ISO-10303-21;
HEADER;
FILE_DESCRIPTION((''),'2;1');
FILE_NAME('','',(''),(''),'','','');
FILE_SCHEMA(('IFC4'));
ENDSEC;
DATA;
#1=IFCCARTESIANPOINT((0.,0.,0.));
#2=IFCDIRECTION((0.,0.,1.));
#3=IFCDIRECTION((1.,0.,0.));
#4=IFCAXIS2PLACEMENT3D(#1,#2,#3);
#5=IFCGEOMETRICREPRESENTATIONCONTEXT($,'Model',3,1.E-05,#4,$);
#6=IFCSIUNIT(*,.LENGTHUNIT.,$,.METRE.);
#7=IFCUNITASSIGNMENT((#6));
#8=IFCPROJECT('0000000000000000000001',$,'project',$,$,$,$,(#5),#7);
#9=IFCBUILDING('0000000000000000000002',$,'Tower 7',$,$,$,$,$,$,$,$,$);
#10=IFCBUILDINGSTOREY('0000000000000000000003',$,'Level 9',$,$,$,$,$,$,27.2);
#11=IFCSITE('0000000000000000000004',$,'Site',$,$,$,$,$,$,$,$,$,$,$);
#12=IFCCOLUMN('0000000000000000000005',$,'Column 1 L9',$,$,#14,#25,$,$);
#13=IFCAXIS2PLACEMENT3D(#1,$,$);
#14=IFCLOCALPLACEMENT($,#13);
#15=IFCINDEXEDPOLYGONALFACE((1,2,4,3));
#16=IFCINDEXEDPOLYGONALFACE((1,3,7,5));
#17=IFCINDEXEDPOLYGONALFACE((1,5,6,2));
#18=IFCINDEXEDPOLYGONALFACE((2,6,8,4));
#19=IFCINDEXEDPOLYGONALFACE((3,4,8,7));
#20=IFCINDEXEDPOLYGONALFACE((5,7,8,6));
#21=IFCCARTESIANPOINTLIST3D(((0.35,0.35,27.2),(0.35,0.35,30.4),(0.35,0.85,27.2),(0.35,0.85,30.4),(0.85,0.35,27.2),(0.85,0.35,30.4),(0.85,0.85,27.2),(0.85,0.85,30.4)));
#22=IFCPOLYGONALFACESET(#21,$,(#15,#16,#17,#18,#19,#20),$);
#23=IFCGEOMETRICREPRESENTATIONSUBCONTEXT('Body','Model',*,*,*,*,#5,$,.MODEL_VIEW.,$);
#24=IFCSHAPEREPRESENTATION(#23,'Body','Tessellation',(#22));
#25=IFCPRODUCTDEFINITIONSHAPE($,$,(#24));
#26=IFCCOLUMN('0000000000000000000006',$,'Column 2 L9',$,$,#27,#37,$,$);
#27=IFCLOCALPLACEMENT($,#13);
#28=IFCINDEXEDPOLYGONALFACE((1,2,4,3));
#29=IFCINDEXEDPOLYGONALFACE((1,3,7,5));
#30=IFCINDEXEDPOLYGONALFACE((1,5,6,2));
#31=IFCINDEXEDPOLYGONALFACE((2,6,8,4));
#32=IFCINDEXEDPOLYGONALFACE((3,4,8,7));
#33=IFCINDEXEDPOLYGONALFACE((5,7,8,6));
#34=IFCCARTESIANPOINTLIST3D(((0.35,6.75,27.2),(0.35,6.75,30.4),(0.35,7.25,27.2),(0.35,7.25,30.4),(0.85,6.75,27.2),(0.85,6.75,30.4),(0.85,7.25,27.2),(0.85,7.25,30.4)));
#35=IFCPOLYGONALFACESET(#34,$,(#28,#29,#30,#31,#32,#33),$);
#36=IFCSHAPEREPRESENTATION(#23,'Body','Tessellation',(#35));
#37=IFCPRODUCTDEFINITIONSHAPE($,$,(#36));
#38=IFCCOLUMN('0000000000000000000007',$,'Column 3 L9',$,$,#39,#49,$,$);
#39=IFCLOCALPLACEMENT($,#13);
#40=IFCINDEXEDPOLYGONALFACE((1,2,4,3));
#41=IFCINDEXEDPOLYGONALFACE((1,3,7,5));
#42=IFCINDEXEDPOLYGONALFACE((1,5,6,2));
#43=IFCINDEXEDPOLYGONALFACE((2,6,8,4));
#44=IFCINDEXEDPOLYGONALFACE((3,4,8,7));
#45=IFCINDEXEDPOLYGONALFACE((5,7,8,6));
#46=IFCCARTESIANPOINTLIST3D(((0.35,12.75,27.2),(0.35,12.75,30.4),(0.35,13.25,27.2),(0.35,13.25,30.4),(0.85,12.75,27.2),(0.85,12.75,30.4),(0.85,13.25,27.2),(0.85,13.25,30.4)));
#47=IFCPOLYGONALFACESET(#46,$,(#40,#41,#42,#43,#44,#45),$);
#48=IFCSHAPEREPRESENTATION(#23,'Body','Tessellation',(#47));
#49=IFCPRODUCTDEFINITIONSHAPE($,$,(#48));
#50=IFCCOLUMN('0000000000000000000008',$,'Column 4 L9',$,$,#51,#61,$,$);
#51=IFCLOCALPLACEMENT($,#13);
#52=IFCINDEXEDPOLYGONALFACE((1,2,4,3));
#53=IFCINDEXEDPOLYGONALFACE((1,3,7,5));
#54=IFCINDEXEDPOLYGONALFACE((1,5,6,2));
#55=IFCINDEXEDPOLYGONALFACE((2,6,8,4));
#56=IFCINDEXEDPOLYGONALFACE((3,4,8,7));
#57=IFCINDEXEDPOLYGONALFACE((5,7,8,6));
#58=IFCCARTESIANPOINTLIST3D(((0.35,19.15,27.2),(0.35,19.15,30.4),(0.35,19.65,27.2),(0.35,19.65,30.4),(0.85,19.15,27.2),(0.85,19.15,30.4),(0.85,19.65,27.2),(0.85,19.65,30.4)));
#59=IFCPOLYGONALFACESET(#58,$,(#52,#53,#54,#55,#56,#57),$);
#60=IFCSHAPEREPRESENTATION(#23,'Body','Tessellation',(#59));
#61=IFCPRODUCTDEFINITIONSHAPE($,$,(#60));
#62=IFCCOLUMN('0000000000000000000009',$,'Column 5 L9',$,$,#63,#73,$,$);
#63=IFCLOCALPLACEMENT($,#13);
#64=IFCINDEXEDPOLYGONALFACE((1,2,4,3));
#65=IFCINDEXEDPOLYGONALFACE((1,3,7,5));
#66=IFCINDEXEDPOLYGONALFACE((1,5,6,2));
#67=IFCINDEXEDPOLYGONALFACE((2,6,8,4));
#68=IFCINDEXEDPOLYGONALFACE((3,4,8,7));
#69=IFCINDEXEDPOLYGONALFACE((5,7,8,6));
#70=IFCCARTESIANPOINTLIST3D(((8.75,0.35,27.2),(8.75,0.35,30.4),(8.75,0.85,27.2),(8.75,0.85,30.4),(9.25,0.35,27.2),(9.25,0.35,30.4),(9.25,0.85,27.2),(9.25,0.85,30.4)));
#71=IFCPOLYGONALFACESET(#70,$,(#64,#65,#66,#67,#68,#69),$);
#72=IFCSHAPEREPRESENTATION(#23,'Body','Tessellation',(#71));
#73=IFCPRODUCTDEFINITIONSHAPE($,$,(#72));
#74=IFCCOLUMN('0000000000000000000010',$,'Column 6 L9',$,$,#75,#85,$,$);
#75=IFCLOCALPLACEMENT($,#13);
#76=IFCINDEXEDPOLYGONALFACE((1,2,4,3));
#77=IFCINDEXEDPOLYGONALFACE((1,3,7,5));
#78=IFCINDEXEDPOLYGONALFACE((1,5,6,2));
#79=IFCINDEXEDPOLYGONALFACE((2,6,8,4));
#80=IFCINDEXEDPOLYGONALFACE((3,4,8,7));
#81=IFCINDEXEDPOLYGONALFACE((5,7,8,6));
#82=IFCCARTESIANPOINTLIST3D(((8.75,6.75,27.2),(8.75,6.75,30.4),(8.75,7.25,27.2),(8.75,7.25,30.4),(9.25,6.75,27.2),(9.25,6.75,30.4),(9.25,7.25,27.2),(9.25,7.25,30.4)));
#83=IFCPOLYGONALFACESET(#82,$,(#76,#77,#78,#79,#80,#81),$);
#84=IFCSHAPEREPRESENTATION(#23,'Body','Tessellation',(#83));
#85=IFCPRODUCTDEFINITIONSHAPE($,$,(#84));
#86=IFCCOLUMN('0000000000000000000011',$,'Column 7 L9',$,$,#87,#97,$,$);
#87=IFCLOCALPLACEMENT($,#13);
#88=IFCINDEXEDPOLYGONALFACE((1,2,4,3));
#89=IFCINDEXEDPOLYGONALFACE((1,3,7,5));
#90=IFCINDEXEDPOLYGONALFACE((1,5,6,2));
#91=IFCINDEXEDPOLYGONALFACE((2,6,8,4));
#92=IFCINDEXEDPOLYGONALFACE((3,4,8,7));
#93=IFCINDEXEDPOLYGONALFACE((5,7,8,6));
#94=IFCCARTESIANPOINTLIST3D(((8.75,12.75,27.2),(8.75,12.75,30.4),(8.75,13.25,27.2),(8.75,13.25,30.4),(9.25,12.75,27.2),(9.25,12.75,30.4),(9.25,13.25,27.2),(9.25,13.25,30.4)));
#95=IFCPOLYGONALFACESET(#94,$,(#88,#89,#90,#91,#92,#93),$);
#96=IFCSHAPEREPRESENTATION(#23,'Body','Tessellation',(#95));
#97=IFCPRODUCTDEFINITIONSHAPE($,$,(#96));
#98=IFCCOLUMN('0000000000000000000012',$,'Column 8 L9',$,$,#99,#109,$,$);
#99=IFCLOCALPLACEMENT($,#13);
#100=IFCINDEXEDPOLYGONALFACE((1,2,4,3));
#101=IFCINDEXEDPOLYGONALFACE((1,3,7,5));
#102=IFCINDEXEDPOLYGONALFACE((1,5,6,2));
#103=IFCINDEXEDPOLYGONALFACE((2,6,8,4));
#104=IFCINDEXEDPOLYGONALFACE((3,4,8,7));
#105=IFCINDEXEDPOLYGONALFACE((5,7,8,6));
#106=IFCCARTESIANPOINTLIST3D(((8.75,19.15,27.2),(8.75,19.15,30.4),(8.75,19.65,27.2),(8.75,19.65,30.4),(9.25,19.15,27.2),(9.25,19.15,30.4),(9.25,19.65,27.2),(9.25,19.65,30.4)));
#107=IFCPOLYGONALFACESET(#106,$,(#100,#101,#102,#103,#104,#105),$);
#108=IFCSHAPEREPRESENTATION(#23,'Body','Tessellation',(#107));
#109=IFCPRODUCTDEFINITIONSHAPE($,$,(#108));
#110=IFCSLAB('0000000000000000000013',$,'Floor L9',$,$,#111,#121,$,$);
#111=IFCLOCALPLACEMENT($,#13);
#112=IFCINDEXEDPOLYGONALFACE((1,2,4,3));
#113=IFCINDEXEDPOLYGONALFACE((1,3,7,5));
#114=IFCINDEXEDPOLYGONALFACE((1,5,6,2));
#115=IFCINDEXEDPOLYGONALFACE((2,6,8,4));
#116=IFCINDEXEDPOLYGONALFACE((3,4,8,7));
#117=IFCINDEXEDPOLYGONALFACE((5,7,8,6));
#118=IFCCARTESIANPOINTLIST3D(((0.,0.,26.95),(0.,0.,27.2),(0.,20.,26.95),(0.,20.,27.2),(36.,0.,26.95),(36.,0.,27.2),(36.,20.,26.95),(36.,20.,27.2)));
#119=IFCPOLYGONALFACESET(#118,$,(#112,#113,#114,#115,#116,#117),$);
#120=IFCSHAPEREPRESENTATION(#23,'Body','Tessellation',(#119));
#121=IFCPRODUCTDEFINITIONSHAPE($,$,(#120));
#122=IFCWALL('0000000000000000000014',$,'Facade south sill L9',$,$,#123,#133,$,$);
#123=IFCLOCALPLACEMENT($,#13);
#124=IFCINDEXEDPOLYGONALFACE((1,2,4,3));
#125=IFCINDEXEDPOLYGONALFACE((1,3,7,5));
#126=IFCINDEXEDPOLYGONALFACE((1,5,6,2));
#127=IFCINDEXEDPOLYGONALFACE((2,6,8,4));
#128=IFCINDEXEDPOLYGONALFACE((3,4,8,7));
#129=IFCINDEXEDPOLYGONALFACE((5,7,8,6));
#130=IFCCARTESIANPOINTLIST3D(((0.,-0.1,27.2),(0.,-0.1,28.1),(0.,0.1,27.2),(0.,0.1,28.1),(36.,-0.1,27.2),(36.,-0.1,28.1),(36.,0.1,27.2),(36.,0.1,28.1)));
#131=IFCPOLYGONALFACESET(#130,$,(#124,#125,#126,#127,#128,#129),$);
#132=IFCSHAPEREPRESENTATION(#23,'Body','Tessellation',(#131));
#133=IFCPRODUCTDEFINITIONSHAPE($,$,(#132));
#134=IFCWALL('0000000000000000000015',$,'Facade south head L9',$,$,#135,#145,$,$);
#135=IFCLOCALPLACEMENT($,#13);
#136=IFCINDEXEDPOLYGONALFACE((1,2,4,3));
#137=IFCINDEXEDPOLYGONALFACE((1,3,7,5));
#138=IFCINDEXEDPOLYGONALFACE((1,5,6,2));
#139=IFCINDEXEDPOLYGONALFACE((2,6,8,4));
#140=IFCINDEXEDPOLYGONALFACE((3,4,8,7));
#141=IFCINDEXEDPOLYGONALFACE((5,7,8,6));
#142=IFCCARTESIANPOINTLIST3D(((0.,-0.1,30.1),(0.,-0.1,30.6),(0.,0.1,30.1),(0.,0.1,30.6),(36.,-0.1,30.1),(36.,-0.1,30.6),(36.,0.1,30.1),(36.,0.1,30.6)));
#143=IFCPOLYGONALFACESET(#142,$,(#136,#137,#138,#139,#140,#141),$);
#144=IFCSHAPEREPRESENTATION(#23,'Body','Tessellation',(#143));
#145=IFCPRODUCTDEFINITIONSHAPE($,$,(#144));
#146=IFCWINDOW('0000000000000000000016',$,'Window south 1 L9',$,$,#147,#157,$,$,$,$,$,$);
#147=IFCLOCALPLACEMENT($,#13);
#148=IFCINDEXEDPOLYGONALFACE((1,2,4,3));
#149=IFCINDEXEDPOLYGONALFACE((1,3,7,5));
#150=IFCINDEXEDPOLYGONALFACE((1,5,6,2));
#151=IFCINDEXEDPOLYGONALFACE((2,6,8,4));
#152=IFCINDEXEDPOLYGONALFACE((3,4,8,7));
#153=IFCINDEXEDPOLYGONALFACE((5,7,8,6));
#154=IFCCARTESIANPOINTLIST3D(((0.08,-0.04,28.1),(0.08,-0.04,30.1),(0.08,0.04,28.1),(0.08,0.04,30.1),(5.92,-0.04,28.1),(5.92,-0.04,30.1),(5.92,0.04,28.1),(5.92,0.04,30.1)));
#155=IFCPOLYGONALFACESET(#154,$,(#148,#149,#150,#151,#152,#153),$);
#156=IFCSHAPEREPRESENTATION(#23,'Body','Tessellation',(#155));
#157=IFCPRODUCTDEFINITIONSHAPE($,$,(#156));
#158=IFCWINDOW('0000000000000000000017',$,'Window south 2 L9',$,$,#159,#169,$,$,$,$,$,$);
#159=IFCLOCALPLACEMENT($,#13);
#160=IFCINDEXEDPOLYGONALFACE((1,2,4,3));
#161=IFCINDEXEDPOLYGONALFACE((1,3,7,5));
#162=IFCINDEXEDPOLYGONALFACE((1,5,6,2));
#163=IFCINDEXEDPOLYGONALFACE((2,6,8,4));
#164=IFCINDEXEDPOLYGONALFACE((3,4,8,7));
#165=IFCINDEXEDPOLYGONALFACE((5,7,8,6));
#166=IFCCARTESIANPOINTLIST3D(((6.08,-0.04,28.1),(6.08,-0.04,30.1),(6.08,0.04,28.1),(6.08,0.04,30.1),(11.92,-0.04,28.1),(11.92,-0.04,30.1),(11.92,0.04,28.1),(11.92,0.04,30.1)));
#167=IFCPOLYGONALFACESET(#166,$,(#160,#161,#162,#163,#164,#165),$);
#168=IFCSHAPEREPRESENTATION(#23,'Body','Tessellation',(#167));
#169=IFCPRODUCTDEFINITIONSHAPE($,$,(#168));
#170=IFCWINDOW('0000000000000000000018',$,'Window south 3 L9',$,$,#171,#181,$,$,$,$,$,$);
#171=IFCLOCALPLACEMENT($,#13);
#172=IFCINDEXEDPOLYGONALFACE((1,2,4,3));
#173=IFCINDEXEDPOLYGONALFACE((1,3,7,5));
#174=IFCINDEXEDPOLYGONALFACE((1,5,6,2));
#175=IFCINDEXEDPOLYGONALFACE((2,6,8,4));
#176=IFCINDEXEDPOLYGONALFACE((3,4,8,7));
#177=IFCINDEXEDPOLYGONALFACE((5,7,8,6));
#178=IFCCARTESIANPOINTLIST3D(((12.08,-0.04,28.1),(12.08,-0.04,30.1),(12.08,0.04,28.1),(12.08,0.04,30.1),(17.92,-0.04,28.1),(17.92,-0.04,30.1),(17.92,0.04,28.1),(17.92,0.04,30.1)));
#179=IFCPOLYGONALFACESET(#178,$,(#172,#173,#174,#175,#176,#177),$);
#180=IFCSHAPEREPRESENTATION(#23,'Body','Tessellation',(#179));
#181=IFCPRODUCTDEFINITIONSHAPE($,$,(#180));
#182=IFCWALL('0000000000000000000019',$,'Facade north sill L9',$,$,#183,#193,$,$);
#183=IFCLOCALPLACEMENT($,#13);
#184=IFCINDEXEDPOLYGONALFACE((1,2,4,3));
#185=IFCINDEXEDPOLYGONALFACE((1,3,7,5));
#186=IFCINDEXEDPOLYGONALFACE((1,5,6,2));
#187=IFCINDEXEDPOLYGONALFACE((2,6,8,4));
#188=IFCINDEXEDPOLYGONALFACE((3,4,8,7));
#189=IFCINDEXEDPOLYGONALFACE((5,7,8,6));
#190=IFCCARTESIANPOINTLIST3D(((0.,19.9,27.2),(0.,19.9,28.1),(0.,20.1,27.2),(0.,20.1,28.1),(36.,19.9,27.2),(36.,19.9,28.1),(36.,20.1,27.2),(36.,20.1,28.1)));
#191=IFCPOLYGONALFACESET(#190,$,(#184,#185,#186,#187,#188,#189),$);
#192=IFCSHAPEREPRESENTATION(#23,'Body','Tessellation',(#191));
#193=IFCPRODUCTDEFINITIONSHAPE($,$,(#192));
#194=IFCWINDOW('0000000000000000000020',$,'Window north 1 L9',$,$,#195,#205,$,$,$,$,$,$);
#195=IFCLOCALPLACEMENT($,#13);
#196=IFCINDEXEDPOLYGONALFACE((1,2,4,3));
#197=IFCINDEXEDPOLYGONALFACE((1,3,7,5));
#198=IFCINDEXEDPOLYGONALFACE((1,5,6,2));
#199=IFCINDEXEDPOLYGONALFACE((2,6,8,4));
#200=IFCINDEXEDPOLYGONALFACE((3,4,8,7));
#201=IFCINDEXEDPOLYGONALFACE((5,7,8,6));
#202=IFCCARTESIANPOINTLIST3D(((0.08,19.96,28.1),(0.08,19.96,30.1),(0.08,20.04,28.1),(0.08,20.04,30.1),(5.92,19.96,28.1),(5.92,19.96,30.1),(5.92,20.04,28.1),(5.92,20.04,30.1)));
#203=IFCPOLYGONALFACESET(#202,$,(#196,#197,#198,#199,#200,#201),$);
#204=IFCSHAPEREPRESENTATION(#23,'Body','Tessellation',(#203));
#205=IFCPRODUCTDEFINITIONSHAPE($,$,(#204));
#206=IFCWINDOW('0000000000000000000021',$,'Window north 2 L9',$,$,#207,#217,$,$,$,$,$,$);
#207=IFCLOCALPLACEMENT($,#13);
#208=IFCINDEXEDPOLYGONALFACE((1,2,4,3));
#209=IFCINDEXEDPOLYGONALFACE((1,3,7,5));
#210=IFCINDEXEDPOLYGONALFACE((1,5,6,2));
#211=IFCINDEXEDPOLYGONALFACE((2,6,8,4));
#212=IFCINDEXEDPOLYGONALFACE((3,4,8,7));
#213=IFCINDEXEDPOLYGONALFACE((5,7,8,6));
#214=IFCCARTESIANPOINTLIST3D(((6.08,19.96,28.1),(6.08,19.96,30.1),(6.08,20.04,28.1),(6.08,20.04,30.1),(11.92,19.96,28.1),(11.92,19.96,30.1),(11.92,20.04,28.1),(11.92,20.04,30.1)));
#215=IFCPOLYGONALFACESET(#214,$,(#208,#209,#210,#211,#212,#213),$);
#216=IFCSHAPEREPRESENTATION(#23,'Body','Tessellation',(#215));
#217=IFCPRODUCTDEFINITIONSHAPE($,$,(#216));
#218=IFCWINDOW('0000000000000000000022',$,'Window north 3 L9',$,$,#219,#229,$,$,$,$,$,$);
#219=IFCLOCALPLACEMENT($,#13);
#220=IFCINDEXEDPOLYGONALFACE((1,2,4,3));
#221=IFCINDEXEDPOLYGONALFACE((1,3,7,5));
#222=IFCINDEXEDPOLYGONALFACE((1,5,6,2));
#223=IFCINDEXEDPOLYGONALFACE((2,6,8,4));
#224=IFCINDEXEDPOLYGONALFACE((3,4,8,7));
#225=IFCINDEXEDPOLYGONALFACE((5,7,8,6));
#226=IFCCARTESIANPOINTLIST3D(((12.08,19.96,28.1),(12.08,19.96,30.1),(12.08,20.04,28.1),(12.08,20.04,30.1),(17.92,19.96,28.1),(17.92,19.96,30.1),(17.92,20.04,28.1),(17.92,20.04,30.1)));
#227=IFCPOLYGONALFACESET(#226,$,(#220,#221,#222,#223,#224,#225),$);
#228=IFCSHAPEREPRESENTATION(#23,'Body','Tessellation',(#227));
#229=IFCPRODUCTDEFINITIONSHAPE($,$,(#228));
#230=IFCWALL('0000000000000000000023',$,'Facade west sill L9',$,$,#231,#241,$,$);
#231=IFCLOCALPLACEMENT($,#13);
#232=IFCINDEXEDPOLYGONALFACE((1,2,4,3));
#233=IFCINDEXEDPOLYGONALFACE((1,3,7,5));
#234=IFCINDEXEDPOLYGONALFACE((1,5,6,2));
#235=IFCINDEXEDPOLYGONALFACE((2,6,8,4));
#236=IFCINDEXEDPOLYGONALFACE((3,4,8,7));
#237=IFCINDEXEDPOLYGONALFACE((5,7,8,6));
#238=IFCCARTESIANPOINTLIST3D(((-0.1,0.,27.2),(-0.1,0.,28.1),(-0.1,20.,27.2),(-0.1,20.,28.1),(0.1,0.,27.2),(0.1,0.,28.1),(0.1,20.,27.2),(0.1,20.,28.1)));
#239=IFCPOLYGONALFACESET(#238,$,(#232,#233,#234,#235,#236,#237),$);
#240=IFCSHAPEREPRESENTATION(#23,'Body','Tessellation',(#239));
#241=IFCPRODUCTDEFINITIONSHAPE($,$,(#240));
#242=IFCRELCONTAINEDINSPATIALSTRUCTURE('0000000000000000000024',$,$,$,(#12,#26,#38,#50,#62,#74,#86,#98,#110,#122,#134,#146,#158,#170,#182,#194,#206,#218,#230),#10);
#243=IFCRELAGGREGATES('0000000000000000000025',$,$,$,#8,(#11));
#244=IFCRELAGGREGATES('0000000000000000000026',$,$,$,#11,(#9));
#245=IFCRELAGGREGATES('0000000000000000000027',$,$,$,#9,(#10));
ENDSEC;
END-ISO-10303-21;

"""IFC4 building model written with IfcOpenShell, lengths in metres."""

from ifc_helpers import new_model, si_unit, frame, origin, origin_with_axes, origin_2d, place, context, subcontext, project, spatial, rectangle, extrude, element, save


model = new_model("IFC4")

# Units and contexts
model_context = context("Model", 3, precision=1e-05, world=origin_with_axes())
body_context = subcontext(model_context, "Body", "Model", "MODEL_VIEW")
ifc_project = project(units=[si_unit("LENGTHUNIT", "METRE")], contexts=[model_context])

# Site, building, storey
site = spatial("IfcSite", under=ifc_project, Name="Site")
building = spatial("IfcBuilding", under=site, Name="Tower 7")
storey = spatial("IfcBuildingStorey", under=building, Name="Level 9", Elevation=27.2)

# Columns
for number, where, z_axis, x_axis, name in (
    (1, (0.6, 0.6, 27.2), (0.0, 0.0, 1.0), (1.0, 0.0, 0.0), "Column 1 L9"),
    (2, (0.6, 7.0, 27.2), (0.0, 0.0, 1.0), (1.0, 0.0, 0.0), "Column 2 L9"),
    (3, (0.6, 13.0, 27.2), (0.0, 0.0, 1.0), (1.0, 0.0, 0.0), "Column 3 L9"),
    (4, (0.6, 19.4, 27.2), (0.0, 0.0, 1.0), (1.0, 0.0, 0.0), "Column 4 L9"),
    (5, (9.0, 0.6, 27.2), (0.0, 0.0, 1.0), (1.0, 0.0, 0.0), "Column 5 L9"),
    (6, (9.0, 7.0, 27.2), (0.0, 0.0, 1.0), (1.0, 0.0, 0.0), "Column 6 L9"),
    (7, (9.0, 13.0, 27.2), (0.0, 0.0, 1.0), (1.0, 0.0, 0.0), "Column 7 L9"),
    (8, (9.0, 19.4, 27.2), (0.0, 0.0, 1.0), (1.0, 0.0, 0.0), "Column 8 L9"),
):
    element("IfcColumn", number, at=place(None, frame(where, z_axis=z_axis, x_axis=x_axis)), inside=storey, Name=name, context=body_context, shape_type="SweptSolid", body=[
        extrude(rectangle(XDim=0.5, YDim=0.5, at=origin_2d()), origin(), (0.0, 0.0, 1.0), 3.2),
    ])

# Slab
slab_placement = place(None, frame((18.0, 10.0, 26.95), z_axis=(0.0, 0.0, 1.0), x_axis=(1.0, 0.0, 0.0)))
element("IfcSlab", 9, at=slab_placement, inside=storey, Name="Floor L9", context=body_context, shape_type="SweptSolid", body=[
    extrude(rectangle(XDim=36.0, YDim=20.0, at=origin_2d()), origin(), (0.0, 0.0, 1.0), 0.25),
])

# Walls
wall_1_placement = place(None, frame((18.0, 0.0, 27.2), z_axis=(0.0, 0.0, 1.0), x_axis=(1.0, 0.0, 0.0)))
element("IfcWall", 10, at=wall_1_placement, inside=storey, Name="Facade south sill L9", context=body_context, shape_type="SweptSolid", body=[
    extrude(rectangle(XDim=36.0, YDim=0.2, at=origin_2d()), origin(), (0.0, 0.0, 1.0), 0.9),
])
wall_2_placement = place(None, frame((18.0, 0.0, 30.1), z_axis=(0.0, 0.0, 1.0), x_axis=(1.0, 0.0, 0.0)))
element("IfcWall", 11, at=wall_2_placement, inside=storey, Name="Facade south head L9", context=body_context, shape_type="SweptSolid", body=[
    extrude(rectangle(XDim=36.0, YDim=0.2, at=origin_2d()), origin(), (0.0, 0.0, 1.0), 0.5),
])

# Windows
for number, where, z_axis, x_axis, name in (
    (12, (3.0, 0.0, 28.1), (0.0, 0.0, 1.0), (1.0, 0.0, 0.0), "Window south 1 L9"),
    (13, (9.0, 0.0, 28.1), (0.0, 0.0, 1.0), (1.0, 0.0, 0.0), "Window south 2 L9"),
):
    element("IfcWindow", number, at=place(None, frame(where, z_axis=z_axis, x_axis=x_axis)), inside=storey, Name=name, context=body_context, shape_type="SweptSolid", body=[
        extrude(rectangle(XDim=5.84, YDim=0.08, at=origin_2d()), origin(), (0.0, 0.0, 1.0), 2.0),
    ])
window_1_placement = place(None, frame((15.0, 0.0, 28.1), z_axis=(0.0, 0.0, 1.0), x_axis=(1.0, 0.0, 0.0)))
element("IfcWindow", 14, at=window_1_placement, inside=storey, Name="Window south 3 L9", context=body_context, shape_type="SweptSolid", body=[
    extrude(rectangle(XDim=5.84, YDim=0.08, at=origin_2d()), origin(), (0.0, 0.0, 1.0), 2.0),
])

# Wall
wall_3_placement = place(None, frame((18.0, 20.0, 27.2), z_axis=(0.0, 0.0, 1.0), x_axis=(1.0, 0.0, 0.0)))
element("IfcWall", 15, at=wall_3_placement, inside=storey, Name="Facade north sill L9", context=body_context, shape_type="SweptSolid", body=[
    extrude(rectangle(XDim=36.0, YDim=0.2, at=origin_2d()), origin(), (0.0, 0.0, 1.0), 0.9),
])

# Windows
for number, where, z_axis, x_axis, name in (
    (16, (3.0, 20.0, 28.1), (0.0, 0.0, 1.0), (1.0, 0.0, 0.0), "Window north 1 L9"),
    (17, (9.0, 20.0, 28.1), (0.0, 0.0, 1.0), (1.0, 0.0, 0.0), "Window north 2 L9"),
):
    element("IfcWindow", number, at=place(None, frame(where, z_axis=z_axis, x_axis=x_axis)), inside=storey, Name=name, context=body_context, shape_type="SweptSolid", body=[
        extrude(rectangle(XDim=5.84, YDim=0.08, at=origin_2d()), origin(), (0.0, 0.0, 1.0), 2.0),
    ])
window_2_placement = place(None, frame((15.0, 20.0, 28.1), z_axis=(0.0, 0.0, 1.0), x_axis=(1.0, 0.0, 0.0)))
element("IfcWindow", 18, at=window_2_placement, inside=storey, Name="Window north 3 L9", context=body_context, shape_type="SweptSolid", body=[
    extrude(rectangle(XDim=5.84, YDim=0.08, at=origin_2d()), origin(), (0.0, 0.0, 1.0), 2.0),
])

# Wall
wall_4_placement = place(None, frame((0.0, 10.0, 27.2), z_axis=(0.0, 0.0, 1.0), x_axis=(1.0, 0.0, 0.0)))
element("IfcWall", 19, at=wall_4_placement, inside=storey, Name="Facade west sill L9", context=body_context, shape_type="SweptSolid", body=[
    extrude(rectangle(XDim=0.2, YDim=20.0, at=origin_2d()), origin(), (0.0, 0.0, 1.0), 0.9),
])

save(model, "model.ifc")
